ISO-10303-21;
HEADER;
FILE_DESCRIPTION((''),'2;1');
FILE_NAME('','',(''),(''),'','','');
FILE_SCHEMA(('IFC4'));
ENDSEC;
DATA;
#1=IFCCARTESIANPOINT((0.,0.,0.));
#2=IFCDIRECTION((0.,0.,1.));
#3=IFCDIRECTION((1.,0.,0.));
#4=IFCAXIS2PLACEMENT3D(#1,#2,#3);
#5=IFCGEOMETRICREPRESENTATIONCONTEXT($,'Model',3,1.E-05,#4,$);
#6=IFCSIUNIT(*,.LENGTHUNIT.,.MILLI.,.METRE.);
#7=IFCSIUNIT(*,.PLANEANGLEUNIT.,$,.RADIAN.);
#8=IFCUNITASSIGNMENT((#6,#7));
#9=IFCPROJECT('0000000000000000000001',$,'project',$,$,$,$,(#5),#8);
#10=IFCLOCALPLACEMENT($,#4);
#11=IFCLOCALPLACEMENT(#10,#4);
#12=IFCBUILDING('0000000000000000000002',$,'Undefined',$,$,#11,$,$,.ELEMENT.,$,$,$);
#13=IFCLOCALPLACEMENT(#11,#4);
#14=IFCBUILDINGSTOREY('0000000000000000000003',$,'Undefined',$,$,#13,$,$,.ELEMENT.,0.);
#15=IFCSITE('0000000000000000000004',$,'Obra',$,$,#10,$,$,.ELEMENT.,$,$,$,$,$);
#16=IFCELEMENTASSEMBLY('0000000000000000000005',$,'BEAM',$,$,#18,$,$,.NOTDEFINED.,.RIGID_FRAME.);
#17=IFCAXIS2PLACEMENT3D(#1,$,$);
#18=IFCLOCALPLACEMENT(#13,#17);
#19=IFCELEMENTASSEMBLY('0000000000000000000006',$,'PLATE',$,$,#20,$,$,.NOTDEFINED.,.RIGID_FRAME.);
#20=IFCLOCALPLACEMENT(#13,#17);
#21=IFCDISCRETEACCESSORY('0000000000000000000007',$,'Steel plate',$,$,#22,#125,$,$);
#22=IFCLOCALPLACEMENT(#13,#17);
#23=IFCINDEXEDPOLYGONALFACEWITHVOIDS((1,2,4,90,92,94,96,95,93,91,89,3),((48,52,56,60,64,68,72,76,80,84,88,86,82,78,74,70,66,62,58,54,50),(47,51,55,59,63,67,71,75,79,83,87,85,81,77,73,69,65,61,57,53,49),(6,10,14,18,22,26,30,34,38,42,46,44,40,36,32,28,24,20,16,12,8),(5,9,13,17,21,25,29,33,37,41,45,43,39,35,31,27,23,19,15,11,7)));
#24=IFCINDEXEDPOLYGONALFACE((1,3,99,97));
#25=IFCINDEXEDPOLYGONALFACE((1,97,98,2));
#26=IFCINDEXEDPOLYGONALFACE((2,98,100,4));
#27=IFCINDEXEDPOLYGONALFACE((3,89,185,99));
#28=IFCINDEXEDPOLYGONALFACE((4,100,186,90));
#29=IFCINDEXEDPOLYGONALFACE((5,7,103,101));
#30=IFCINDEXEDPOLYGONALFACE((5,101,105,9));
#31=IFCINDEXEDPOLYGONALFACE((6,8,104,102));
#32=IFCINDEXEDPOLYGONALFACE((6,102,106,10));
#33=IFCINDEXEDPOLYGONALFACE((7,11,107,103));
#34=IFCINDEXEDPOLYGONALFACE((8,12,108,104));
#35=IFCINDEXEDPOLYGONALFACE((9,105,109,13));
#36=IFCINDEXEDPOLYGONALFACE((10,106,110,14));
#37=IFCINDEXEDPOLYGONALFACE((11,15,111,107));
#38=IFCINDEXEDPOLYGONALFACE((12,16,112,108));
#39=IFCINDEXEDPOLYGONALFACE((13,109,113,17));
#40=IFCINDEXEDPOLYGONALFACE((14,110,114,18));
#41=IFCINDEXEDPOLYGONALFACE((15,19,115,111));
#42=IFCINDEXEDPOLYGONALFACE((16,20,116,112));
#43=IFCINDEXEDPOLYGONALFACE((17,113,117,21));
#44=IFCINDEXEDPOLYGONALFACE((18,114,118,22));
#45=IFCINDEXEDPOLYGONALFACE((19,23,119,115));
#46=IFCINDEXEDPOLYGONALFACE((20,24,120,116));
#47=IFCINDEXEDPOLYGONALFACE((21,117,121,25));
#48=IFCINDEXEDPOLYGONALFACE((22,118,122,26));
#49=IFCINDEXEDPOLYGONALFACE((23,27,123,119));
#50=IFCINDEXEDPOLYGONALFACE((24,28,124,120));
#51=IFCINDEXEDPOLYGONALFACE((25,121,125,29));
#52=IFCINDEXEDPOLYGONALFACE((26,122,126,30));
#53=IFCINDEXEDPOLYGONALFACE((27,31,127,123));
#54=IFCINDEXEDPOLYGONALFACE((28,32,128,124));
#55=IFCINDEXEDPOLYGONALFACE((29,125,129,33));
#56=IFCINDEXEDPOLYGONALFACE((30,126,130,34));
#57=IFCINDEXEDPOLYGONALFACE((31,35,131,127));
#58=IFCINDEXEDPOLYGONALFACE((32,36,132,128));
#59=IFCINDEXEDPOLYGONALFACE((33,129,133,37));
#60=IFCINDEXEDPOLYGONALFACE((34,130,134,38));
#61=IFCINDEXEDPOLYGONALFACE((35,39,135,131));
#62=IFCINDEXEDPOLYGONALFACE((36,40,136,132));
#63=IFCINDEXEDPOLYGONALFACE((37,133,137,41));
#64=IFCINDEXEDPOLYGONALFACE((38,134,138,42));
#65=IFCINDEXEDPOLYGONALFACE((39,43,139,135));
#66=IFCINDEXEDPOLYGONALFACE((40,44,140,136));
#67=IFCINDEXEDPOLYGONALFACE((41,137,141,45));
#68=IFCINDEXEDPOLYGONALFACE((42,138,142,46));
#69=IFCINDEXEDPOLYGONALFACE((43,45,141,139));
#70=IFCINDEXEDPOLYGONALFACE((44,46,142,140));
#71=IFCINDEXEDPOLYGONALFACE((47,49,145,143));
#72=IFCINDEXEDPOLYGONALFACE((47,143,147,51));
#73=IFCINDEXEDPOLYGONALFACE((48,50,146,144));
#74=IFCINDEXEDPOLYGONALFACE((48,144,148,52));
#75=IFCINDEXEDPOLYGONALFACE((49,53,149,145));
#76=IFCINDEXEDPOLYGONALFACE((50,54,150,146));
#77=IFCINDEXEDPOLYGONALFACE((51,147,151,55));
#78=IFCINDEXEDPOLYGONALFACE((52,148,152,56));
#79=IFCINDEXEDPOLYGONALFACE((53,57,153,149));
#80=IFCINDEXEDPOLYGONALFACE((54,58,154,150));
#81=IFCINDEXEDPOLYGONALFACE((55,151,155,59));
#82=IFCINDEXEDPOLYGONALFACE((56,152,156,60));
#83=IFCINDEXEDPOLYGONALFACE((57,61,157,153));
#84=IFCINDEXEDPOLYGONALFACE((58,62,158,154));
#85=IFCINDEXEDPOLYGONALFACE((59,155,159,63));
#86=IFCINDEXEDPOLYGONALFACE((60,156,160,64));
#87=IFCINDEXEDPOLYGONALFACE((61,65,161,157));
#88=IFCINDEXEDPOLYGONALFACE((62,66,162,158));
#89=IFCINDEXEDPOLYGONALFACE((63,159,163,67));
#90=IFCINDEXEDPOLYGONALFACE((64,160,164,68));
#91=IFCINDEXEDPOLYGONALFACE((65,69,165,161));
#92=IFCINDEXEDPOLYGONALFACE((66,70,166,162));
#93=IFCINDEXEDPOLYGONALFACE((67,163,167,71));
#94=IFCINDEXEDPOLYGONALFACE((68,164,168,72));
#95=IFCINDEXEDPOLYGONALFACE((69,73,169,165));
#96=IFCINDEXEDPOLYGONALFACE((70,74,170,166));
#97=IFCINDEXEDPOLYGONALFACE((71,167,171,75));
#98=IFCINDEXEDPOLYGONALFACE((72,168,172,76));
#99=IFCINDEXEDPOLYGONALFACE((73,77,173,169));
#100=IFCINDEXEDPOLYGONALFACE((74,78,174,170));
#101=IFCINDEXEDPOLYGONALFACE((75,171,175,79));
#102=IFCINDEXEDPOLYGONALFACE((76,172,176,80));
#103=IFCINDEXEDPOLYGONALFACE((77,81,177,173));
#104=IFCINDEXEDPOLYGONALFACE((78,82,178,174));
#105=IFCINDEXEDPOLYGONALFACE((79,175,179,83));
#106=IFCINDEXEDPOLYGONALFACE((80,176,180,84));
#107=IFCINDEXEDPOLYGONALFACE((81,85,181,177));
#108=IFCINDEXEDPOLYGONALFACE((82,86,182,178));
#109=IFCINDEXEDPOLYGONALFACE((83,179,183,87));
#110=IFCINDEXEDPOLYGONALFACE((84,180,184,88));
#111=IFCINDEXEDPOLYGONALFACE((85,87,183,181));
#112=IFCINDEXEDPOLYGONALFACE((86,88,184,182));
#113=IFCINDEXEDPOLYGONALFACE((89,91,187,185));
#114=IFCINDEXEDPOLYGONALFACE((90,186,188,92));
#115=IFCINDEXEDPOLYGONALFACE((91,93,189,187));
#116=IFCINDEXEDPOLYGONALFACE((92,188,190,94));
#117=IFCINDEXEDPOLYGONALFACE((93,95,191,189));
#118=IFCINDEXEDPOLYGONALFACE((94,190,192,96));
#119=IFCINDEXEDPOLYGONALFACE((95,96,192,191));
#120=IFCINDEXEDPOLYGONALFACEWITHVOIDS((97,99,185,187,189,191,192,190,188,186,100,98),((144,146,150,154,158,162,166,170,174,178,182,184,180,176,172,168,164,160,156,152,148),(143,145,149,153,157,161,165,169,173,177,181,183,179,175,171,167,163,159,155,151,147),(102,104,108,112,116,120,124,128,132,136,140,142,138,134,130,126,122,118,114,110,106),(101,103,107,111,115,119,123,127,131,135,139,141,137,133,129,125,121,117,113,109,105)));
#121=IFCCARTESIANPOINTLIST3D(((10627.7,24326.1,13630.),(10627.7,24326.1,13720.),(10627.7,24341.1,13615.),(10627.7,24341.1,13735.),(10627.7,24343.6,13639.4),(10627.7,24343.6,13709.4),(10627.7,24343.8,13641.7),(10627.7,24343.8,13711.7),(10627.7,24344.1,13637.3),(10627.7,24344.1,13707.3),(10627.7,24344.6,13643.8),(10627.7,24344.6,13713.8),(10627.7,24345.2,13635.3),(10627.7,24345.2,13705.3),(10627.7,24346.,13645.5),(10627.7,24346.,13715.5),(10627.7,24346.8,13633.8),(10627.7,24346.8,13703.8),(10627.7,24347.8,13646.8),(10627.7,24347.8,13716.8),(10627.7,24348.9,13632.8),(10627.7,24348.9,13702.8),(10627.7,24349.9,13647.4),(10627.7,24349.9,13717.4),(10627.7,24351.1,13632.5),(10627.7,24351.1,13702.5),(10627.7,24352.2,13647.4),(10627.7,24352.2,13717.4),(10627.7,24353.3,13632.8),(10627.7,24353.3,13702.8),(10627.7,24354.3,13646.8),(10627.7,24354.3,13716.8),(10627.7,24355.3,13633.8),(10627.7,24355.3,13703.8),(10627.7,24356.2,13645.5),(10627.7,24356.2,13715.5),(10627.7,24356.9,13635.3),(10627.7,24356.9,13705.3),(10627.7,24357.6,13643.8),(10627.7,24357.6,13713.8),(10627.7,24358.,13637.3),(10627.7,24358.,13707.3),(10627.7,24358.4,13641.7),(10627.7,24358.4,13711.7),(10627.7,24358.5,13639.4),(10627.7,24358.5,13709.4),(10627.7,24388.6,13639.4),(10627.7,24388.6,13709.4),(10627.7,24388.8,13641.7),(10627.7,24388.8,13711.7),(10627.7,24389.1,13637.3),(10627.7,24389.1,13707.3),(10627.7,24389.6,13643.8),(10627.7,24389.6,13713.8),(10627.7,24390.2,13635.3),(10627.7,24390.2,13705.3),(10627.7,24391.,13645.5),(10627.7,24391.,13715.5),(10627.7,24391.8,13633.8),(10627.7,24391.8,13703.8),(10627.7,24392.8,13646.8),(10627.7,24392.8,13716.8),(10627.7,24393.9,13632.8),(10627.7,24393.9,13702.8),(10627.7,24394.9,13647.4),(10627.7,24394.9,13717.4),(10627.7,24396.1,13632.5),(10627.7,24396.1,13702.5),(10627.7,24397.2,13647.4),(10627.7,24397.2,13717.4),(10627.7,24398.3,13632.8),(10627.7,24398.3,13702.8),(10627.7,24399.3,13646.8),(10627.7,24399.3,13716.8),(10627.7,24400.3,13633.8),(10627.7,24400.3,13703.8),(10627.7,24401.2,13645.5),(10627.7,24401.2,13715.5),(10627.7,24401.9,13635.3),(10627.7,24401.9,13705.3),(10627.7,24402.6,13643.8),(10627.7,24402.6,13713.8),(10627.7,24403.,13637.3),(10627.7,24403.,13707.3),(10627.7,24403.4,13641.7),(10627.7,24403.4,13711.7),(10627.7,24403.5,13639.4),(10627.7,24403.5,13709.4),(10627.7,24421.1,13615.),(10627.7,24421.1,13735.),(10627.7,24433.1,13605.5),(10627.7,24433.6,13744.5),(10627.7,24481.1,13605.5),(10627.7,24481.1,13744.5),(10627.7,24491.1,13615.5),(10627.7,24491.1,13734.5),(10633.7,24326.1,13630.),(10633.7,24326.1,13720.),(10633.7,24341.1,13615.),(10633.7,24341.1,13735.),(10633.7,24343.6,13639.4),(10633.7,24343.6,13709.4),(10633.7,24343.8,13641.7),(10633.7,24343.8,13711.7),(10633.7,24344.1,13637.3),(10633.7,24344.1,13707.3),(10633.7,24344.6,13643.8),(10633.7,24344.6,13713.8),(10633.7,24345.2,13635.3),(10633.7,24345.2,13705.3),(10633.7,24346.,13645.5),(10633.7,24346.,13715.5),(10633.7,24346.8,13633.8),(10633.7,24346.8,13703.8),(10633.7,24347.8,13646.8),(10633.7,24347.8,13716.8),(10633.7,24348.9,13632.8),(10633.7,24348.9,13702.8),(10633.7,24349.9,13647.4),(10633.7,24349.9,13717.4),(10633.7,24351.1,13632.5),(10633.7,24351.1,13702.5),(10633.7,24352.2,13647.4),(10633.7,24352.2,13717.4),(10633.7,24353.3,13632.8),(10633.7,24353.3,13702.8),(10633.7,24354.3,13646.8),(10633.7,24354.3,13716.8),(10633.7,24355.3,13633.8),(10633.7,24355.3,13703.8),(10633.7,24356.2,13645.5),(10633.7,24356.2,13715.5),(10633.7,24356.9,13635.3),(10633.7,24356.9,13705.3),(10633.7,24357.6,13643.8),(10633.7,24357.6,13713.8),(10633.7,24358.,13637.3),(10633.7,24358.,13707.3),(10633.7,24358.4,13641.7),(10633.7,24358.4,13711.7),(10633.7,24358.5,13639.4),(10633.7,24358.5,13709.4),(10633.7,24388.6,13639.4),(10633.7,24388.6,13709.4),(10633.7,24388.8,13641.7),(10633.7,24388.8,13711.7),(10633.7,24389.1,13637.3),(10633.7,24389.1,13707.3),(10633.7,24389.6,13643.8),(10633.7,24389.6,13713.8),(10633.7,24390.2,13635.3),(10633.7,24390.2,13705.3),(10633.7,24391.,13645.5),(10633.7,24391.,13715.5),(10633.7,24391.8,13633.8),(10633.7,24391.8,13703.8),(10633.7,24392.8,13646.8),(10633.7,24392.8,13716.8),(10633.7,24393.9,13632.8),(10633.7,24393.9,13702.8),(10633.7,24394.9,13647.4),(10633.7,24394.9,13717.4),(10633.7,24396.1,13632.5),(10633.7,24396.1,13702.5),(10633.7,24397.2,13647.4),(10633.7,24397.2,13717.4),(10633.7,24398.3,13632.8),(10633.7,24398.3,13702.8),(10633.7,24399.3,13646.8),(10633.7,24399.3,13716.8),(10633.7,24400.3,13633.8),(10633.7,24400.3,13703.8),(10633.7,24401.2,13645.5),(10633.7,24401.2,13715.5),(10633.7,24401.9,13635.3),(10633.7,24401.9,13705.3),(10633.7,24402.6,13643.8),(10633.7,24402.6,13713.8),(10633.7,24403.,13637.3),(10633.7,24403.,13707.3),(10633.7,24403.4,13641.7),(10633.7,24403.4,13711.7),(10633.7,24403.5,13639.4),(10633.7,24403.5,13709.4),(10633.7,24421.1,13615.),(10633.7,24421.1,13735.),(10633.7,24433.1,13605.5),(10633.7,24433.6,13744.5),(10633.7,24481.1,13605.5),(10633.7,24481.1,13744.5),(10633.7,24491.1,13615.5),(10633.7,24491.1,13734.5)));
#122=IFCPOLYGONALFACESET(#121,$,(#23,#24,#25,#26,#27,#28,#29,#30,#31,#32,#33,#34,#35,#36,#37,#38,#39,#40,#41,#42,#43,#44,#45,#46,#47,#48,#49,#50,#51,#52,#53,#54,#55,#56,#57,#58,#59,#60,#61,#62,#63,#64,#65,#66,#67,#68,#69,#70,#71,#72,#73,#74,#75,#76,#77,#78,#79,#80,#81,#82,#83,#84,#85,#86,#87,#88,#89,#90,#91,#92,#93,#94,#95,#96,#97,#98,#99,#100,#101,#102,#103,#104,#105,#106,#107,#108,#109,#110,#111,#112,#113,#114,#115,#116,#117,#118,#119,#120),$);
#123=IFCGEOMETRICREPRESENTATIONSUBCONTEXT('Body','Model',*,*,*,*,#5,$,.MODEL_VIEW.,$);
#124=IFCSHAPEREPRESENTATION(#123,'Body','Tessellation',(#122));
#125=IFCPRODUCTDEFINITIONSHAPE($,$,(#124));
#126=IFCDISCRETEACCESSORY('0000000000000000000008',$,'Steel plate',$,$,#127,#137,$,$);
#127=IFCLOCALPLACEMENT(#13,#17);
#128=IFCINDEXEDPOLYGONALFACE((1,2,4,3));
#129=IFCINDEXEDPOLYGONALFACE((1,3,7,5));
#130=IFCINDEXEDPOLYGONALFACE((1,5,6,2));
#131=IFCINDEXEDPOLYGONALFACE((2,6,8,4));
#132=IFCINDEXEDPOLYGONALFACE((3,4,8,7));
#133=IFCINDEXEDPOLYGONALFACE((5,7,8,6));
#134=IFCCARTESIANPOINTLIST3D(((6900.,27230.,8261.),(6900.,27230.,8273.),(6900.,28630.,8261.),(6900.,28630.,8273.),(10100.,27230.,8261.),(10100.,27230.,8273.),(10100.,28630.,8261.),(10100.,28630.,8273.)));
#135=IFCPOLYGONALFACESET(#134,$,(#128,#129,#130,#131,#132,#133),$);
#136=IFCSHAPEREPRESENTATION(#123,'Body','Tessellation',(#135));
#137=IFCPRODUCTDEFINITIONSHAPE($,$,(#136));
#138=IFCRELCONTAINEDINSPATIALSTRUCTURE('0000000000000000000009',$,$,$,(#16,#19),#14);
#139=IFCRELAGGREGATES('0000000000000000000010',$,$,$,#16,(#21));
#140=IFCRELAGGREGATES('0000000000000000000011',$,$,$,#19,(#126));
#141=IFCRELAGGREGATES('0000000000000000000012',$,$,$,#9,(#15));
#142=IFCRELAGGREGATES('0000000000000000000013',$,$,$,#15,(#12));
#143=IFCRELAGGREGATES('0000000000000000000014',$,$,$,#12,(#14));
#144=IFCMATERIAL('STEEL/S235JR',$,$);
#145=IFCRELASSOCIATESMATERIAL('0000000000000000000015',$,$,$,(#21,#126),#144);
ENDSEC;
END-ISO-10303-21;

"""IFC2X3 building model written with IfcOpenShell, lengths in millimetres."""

from ifc_helpers import new_model, si_unit, frame, origin_with_axes, origin_2d_with_axis, place, context, subcontext, project, spatial, polyline, circle, outline, extrude, source, transform, mapped, material, element, aggregate, save


model = new_model("IFC2X3")

# Units and contexts
model_context = context("Model", 3, precision=1e-05, world=origin_with_axes())
body_context = subcontext(model_context, "Body", "Model", "MODEL_VIEW")
ifc_project = project(units=[si_unit("LENGTHUNIT", "METRE", prefix="MILLI"), si_unit("PLANEANGLEUNIT", "RADIAN")], contexts=[model_context])

# Site, building, storey
site_placement = place(None, origin_with_axes())
site = spatial("IfcSite", under=ifc_project, at=site_placement, Name="Obra", CompositionType="ELEMENT")
building_placement = place(site_placement, origin_with_axes())
building = spatial("IfcBuilding", under=site, at=building_placement, Name="Undefined", CompositionType="ELEMENT")
storey_placement = place(building_placement, origin_with_axes())
storey = spatial("IfcBuildingStorey", under=building, at=storey_placement, Name="Undefined", CompositionType="ELEMENT", Elevation=0.0)

# Shared definitions
ifc_material_1 = material(Name="STEEL/S235JR")

# Element assembly
assembly_1_placement = place(storey_placement, origin_with_axes())
assembly_1 = element("IfcElementAssembly", 1, at=assembly_1_placement, inside=storey, Name="BEAM", AssemblyPlace="NOTDEFINED", PredefinedType="RIGID_FRAME")

# Element assembly
assembly_2_placement = place(storey_placement, origin_with_axes())
assembly_2 = element("IfcElementAssembly", 2, at=assembly_2_placement, inside=storey, Name="PLATE", AssemblyPlace="NOTDEFINED", PredefinedType="RIGID_FRAME")

# Discrete accessory, opening
discrete_accessory_1_placement = place(assembly_1_placement, frame((10630.7, 24491.1, 13615.5), z_axis=(-1.0, 0.0, 0.0), x_axis=(0.000001, -0.707107, -0.707107)))
discrete_accessory_1 = element("IfcDiscreteAccessory", 3, at=discrete_accessory_1_placement, material=ifc_material_1, Name="Steel plate", context=body_context, shape_type="SweptSolid", body=[
    extrude(outline(polyline([(0.0, 0.0), (14.1, 0.0), (48.1, 33.9), (49.9, 49.1), (106.4, 105.7), (106.4, 126.9), (42.8, 190.6), (21.6, 190.6), (-35.0, 134.0), (-50.6, 131.9), (-84.1, 98.3), (-84.1, 84.1), (0.0, 0.0)])), frame((0.0, 0.0, -3.0), z_axis=(0.0, 0.0, 1.0), x_axis=(1.0, 0.0, 0.0)), (0.0, 0.0, 1.0), 6.0),
])
shared_shape_1 = source(origin_with_axes(), body_context, "Body", "SweptSolid", [
    extrude(circle(Radius=7.5, at=origin_2d_with_axis()), frame((0.0, 2.4, 0.0), z_axis=(0.0, 1.0, 0.0), x_axis=(1.0, 0.0, 0.0)), (0.0, 0.0, 1.0), 6.2),
])
opening_1_placement = place(assembly_1_placement, frame((10625.2, 24373.6, 13710.0), z_axis=(0.0, -1.0, 0.0), x_axis=(0.0, 0.0, -1.0)))
element("IfcOpeningElement", 4, at=opening_1_placement, cuts=discrete_accessory_1, ObjectType="Opening", context=body_context, shape_type="MappedRepresentation", body=[
    mapped(shared_shape_1, transform((0.0, 0.0, -22.5))),
    mapped(shared_shape_1, transform((70.0, 0.0, -22.5))),
    mapped(shared_shape_1, transform((0.0, 0.0, 22.5))),
    mapped(shared_shape_1, transform((70.0, 0.0, 22.5))),
])
aggregate(assembly_1, [discrete_accessory_1])

# Discrete accessory
discrete_accessory_2_placement = place(assembly_2_placement, frame((6900.0, 27230.0, 8267.0), z_axis=(0.0, 0.0, 1.0), x_axis=(1.0, 0.0, 0.0)))
discrete_accessory_2 = element("IfcDiscreteAccessory", 5, at=discrete_accessory_2_placement, material=ifc_material_1, Name="Steel plate", context=body_context, shape_type="SweptSolid", body=[
    extrude(outline(polyline([(0.0, 0.0), (3200.0, 0.0), (3200.0, 1400.0), (0.0, 1400.0), (0.0, 0.0)])), frame((0.0, 0.0, -6.0), z_axis=(0.0, 0.0, 1.0), x_axis=(1.0, 0.0, 0.0)), (0.0, 0.0, 1.0), 12.0),
])

aggregate(assembly_2, [discrete_accessory_2])

save(model, "model.ifc")
